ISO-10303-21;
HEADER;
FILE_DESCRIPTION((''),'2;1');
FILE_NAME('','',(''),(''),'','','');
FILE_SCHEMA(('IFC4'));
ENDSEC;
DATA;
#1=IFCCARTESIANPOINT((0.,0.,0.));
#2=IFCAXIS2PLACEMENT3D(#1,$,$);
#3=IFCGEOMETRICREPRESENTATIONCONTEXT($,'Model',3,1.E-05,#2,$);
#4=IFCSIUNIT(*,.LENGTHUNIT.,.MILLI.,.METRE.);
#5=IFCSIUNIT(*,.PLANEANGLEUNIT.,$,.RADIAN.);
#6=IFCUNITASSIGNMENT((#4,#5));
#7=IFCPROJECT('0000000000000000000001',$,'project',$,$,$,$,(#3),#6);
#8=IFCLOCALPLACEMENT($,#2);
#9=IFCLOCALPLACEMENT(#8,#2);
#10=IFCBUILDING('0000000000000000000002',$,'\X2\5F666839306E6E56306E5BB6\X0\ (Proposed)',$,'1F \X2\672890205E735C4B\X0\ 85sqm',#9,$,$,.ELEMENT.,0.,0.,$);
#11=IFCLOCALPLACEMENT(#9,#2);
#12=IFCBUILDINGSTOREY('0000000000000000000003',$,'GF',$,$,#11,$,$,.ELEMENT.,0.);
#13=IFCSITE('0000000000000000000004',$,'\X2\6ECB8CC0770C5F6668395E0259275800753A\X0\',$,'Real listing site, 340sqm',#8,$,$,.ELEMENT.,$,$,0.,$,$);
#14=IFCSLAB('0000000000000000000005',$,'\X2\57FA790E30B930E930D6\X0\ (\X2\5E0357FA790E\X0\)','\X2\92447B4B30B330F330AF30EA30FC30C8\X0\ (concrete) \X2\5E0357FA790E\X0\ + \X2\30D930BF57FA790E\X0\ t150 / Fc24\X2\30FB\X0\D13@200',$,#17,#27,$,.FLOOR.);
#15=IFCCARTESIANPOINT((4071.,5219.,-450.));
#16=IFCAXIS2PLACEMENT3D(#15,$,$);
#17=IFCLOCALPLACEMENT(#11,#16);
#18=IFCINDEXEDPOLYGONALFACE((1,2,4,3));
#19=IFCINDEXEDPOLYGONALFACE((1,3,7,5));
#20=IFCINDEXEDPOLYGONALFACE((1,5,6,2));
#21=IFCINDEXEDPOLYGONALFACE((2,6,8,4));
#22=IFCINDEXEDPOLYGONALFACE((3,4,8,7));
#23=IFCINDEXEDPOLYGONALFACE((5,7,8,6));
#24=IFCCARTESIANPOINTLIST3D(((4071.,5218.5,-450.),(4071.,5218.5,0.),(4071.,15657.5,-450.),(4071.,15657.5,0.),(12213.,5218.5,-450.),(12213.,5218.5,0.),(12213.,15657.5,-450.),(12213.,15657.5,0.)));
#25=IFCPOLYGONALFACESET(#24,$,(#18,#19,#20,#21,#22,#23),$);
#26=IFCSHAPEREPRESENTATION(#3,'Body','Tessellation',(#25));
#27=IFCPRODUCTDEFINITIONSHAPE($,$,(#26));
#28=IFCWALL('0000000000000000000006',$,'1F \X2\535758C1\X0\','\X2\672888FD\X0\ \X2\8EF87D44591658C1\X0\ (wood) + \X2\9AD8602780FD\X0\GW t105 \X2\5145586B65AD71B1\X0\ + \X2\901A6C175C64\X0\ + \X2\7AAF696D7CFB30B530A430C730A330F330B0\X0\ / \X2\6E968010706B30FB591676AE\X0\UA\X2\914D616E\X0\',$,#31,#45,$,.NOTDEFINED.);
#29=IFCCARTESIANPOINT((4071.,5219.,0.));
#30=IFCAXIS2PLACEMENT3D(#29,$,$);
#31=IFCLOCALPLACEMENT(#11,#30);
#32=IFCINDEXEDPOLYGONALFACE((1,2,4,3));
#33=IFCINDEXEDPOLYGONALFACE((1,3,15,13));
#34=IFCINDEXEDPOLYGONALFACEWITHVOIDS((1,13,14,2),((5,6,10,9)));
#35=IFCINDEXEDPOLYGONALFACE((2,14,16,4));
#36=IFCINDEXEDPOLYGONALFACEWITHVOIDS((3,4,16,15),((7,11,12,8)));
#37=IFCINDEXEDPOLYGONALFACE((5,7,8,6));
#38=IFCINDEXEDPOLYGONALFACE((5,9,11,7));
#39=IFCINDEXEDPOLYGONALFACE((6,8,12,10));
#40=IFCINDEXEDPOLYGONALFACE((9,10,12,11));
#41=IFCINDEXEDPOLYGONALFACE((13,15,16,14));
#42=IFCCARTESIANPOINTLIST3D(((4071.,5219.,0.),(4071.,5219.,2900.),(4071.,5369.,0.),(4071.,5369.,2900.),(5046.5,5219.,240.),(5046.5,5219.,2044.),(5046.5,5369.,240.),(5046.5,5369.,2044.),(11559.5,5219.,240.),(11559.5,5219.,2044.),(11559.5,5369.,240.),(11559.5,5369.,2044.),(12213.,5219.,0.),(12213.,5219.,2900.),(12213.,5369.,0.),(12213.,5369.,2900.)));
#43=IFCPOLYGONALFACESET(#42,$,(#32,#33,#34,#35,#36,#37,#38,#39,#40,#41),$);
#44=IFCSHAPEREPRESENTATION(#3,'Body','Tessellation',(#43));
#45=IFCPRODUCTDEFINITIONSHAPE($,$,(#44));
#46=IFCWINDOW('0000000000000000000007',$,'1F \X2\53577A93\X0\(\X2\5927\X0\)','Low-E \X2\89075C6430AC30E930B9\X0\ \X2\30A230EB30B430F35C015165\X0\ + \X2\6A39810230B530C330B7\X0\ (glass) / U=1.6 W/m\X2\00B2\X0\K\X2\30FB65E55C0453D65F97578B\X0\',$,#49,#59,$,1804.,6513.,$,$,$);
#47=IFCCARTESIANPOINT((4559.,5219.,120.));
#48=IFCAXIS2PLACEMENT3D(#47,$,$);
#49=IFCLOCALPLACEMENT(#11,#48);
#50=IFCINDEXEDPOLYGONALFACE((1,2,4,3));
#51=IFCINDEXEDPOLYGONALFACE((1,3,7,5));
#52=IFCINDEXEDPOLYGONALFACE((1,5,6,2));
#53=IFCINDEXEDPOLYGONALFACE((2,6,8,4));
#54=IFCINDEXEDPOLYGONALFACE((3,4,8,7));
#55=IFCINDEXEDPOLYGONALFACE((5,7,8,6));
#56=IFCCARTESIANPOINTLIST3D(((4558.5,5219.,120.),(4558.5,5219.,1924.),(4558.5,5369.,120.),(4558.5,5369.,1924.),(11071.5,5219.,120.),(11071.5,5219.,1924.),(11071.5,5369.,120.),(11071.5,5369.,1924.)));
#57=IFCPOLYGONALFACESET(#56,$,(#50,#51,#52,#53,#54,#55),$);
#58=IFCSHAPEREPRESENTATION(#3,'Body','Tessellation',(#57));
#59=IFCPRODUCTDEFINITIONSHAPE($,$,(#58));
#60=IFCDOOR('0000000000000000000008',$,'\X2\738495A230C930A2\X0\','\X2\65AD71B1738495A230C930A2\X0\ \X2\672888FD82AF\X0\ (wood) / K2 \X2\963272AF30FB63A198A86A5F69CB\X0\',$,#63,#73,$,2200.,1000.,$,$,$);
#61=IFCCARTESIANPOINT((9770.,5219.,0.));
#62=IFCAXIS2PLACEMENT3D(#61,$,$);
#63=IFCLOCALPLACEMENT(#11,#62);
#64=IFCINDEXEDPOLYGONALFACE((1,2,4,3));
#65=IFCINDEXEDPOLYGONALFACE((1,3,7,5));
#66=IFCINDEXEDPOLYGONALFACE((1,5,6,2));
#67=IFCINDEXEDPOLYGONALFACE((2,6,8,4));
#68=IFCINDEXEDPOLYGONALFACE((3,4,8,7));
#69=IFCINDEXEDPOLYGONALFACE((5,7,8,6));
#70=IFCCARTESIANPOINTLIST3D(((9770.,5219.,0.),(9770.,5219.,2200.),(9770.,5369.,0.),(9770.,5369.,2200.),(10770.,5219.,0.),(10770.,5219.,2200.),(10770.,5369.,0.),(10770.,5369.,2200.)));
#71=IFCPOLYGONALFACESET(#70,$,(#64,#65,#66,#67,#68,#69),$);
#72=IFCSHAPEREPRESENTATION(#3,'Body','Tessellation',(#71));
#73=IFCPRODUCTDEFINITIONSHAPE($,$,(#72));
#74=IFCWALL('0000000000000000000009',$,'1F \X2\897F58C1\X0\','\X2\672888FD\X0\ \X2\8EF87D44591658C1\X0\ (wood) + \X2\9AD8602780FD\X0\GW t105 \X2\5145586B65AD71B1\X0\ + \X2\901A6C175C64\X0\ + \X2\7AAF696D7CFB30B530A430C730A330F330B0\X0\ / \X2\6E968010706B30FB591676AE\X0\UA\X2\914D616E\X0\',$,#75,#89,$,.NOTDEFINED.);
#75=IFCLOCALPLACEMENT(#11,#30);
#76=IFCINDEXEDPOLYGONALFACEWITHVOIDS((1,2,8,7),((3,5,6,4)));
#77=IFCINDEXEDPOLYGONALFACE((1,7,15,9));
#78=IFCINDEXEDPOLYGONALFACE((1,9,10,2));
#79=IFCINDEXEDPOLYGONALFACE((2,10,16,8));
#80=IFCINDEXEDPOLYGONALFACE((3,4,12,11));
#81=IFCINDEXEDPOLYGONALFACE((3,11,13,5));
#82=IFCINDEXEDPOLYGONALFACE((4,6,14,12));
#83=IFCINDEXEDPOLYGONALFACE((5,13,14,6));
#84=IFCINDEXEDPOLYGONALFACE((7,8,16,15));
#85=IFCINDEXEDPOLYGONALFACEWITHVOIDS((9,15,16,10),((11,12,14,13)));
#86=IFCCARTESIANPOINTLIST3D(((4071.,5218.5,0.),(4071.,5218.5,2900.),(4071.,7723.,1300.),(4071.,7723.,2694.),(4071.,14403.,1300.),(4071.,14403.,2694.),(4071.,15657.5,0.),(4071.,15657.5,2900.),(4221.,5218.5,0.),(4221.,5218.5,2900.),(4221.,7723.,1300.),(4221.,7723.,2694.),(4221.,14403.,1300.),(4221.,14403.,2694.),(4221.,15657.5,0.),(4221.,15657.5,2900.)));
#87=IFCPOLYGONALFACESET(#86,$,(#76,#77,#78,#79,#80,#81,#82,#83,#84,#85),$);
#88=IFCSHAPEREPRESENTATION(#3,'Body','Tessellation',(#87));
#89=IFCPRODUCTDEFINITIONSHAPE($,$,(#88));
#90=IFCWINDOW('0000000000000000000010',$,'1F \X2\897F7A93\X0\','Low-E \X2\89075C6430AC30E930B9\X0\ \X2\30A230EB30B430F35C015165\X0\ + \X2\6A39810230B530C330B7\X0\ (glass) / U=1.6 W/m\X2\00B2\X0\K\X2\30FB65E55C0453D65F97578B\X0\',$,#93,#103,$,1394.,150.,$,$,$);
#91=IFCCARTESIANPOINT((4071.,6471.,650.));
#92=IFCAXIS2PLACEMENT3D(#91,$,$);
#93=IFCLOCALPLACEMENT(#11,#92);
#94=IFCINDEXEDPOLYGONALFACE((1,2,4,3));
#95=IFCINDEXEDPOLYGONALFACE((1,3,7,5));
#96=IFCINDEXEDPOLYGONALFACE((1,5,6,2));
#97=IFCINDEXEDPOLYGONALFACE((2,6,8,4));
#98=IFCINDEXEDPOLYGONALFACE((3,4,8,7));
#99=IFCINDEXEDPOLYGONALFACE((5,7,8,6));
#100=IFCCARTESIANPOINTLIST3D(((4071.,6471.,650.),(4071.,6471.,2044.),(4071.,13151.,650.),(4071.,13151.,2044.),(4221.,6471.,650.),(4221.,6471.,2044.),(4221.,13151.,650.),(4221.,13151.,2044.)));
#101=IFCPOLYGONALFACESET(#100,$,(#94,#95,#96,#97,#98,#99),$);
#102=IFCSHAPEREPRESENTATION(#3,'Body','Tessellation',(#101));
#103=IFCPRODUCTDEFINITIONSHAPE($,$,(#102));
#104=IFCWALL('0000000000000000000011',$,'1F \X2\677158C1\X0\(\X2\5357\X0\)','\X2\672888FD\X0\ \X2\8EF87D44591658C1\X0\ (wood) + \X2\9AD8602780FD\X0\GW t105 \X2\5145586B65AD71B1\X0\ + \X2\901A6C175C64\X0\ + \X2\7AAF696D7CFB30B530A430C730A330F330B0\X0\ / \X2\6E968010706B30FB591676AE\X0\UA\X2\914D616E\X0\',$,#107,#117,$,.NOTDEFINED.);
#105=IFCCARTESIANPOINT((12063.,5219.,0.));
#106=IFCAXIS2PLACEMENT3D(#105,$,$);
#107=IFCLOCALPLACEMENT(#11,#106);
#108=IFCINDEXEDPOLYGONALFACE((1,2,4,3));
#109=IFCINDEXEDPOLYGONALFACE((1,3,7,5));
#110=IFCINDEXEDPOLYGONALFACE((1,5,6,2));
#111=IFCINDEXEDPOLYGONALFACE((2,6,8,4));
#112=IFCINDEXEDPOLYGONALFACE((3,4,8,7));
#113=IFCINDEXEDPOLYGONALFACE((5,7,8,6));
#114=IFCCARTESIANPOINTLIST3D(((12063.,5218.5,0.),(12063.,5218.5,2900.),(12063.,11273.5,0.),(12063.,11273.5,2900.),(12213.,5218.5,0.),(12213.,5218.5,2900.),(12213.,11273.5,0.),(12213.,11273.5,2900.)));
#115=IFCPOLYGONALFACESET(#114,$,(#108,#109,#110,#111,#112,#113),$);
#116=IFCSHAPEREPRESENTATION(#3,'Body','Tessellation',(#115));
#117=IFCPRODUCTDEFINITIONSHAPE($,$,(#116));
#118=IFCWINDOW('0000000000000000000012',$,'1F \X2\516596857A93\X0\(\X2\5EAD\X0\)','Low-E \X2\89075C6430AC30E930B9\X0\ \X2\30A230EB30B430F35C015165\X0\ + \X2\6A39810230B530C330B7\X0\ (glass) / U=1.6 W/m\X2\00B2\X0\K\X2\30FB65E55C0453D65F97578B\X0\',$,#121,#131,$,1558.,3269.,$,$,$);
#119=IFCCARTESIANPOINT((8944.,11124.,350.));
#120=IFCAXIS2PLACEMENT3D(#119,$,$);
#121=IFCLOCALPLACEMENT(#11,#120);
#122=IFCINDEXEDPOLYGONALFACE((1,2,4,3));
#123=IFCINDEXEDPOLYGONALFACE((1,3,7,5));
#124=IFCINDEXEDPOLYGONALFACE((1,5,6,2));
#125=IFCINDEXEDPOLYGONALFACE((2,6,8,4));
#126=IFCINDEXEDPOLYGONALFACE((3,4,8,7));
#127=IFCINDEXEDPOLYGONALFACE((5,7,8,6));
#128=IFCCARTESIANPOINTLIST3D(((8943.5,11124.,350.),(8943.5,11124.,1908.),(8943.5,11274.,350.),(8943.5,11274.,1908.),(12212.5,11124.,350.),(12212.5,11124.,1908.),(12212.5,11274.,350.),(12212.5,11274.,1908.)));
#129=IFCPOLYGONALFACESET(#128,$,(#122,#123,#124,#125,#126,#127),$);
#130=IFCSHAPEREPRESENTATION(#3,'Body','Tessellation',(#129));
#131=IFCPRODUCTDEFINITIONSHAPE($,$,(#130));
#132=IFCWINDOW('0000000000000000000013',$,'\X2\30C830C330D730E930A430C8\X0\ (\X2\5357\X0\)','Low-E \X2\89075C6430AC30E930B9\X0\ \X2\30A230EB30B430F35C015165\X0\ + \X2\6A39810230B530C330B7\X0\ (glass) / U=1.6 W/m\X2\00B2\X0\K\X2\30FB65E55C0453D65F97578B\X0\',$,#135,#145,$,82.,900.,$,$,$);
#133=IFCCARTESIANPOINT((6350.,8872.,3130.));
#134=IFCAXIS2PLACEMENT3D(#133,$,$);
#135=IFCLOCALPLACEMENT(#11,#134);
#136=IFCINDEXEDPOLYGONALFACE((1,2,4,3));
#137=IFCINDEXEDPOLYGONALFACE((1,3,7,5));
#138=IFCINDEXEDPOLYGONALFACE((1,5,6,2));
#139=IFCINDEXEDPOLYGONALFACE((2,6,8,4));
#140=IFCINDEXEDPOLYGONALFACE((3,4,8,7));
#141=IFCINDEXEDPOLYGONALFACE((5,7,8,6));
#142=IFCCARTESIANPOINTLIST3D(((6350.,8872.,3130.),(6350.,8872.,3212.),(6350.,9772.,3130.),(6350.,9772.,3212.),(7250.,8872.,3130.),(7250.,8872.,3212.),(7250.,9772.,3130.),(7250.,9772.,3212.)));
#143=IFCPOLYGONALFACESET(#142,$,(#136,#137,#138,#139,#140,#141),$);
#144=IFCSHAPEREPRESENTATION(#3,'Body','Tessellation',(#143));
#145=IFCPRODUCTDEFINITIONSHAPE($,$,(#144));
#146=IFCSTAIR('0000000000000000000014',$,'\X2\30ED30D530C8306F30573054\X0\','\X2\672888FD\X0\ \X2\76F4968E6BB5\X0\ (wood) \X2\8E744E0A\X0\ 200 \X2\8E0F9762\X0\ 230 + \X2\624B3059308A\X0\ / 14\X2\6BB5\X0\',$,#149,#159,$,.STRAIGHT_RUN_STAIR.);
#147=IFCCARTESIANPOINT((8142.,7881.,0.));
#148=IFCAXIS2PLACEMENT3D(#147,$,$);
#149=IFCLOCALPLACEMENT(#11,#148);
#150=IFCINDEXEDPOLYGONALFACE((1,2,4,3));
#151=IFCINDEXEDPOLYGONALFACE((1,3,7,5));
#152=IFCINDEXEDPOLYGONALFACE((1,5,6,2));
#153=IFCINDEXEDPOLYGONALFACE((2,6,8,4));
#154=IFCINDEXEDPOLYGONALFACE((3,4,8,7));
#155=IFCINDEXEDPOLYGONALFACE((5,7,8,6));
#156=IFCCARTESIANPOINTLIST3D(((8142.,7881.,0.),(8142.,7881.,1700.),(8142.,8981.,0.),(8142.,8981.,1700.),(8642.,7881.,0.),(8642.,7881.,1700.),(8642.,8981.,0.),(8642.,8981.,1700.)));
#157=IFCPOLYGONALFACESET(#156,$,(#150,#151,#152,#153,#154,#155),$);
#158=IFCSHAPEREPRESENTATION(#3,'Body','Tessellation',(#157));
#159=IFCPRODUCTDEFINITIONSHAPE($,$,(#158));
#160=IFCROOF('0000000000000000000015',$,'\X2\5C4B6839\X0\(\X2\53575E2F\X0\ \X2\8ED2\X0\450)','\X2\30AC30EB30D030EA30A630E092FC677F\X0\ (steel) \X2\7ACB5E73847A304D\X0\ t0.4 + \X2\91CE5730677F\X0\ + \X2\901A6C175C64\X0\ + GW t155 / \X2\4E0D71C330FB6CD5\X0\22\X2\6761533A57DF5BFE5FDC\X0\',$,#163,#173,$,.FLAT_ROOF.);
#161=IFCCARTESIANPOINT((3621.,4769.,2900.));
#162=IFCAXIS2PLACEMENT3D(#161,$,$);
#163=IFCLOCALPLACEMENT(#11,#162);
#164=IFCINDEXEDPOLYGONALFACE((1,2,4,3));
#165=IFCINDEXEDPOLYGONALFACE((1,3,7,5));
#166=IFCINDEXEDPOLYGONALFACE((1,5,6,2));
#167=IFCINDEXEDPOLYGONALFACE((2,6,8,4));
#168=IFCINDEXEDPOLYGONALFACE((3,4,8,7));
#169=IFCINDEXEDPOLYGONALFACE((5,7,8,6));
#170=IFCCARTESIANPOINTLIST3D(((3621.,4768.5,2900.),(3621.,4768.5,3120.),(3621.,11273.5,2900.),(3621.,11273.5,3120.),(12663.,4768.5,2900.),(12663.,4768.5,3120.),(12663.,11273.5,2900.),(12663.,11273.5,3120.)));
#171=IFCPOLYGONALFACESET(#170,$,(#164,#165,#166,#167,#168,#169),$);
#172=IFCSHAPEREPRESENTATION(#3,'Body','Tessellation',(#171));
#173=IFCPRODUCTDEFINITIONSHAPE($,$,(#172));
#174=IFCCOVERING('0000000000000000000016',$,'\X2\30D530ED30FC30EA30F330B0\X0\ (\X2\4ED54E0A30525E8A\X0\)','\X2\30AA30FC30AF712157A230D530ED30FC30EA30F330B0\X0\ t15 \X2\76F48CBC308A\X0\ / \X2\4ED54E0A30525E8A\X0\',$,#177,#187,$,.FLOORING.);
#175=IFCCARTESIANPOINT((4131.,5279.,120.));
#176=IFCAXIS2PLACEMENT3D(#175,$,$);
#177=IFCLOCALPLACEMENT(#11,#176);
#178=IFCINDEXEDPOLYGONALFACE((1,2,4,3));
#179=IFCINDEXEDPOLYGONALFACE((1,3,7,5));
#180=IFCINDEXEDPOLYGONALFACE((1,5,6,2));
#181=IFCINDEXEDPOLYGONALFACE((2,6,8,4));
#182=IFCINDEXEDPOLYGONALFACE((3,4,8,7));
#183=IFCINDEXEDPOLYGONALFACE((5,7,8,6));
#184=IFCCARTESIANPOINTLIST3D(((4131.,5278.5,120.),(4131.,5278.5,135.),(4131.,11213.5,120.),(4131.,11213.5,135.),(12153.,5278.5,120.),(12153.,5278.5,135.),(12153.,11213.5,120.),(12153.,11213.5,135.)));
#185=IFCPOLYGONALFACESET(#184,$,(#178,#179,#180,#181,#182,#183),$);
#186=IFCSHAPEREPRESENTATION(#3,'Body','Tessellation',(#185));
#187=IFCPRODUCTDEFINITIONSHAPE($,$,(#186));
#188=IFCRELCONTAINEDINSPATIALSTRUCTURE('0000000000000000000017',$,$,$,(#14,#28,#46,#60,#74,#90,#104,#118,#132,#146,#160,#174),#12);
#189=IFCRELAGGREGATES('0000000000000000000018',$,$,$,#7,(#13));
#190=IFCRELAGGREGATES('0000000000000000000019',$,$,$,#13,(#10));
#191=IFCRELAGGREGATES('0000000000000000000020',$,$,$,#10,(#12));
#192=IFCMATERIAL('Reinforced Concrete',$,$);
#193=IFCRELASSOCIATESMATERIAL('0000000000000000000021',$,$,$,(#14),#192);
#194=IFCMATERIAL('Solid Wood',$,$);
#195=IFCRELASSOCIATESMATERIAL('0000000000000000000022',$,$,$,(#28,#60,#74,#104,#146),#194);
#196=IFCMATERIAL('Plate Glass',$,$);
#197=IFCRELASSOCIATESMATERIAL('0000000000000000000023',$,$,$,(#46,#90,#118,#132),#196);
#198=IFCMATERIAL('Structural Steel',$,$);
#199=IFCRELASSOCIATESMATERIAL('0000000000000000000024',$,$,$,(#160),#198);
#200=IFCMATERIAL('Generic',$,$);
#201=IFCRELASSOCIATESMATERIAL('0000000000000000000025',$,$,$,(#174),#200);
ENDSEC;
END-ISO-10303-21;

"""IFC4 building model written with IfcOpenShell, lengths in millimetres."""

from ifc_helpers import new_model, si_unit, frame, frame_2d, origin, place, context, project, spatial, rectangle, extrude, material, element, fill, save


model = new_model("IFC4")

# Units and contexts
model_context = context("Model", 3, precision=1e-05, world=origin())
ifc_project = project(units=[si_unit("LENGTHUNIT", "METRE", prefix="MILLI"), si_unit("PLANEANGLEUNIT", "RADIAN")], contexts=[model_context])

# Site, building, storey
site_placement = place(None, origin())
site = spatial("IfcSite", under=ifc_project, at=site_placement, Name="滋賀県彦根市大堀町", ObjectType="Real listing site, 340sqm", CompositionType="ELEMENT", RefElevation=0.0)
building_placement = place(site_placement, origin())
building = spatial("IfcBuilding", under=site, at=building_placement, Name="彦根の湖の家 (Proposed)", ObjectType="1F 木造平屋 85sqm", CompositionType="ELEMENT", ElevationOfRefHeight=0.0, ElevationOfTerrain=0.0)
storey_placement = place(building_placement, origin())
storey = spatial("IfcBuildingStorey", under=building, at=storey_placement, Name="GF", CompositionType="ELEMENT", Elevation=0.0)

# Slab
ifc_material_1 = material(Name="Reinforced Concrete")
slab_1_placement = place(storey_placement, frame((4071.0, 5219.0, -450.0)))
element("IfcSlab", 1, at=slab_1_placement, inside=storey, material=ifc_material_1, Name="基礎スラブ (布基礎)", Description="鉄筋コンクリート (concrete) 布基礎 + ベタ基礎 t150 / Fc24・D13@200", PredefinedType="FLOOR", context=model_context, shape_type="SweptSolid", body=[
    extrude(rectangle(XDim=8142.0, YDim=10439.0, at=frame_2d((4071.0, 5219.0))), frame((4071.0, 5219.0, -450.0)), (0.0, 0.0, 1.0), 450.0),
])
ifc_material_2 = material(Name="Solid Wood")

# Wall, openings, window, door
wall_1_placement = place(storey_placement, frame((4071.0, 5219.0, 0.0)))
wall_1 = element("IfcWall", 2, at=wall_1_placement, inside=storey, material=ifc_material_2, Name="1F 南壁", Description="木製 軸組外壁 (wood) + 高性能GW t105 充填断熱 + 通気層 + 窯業系サイディング / 準耐火・外皮UA配慮", PredefinedType="NOTDEFINED", context=model_context, shape_type="SweptSolid", body=[
    extrude(rectangle(XDim=8142.0, YDim=150.0, at=frame_2d((4071.0, 75.0))), frame((4071.0, 5219.0, 0.0)), (0.0, 0.0, 1.0), 2900.0),
])
opening_1_placement = place(storey_placement, frame((4559.0, 5219.0, 120.0)))
opening_1 = element("IfcOpeningElement", 3, at=opening_1_placement, cuts=wall_1, PredefinedType="NOTDEFINED", context=model_context, shape_type="SweptSolid", body=[
    extrude(rectangle(XDim=6513.0, YDim=150.0, at=frame_2d((3256.0, 75.0))), frame((4559.0, 5219.0, 120.0)), (0.0, 0.0, 1.0), 1804.0),
])
opening_2_placement = place(storey_placement, frame((9770.0, 5219.0, 0.0)))
opening_2 = element("IfcOpeningElement", 4, at=opening_2_placement, cuts=wall_1, PredefinedType="NOTDEFINED", context=model_context, shape_type="SweptSolid", body=[
    extrude(rectangle(XDim=1000.0, YDim=150.0, at=frame_2d((500.0, 75.0))), frame((9770.0, 5219.0, 0.0)), (0.0, 0.0, 1.0), 2200.0),
])
ifc_material_3 = material(Name="Plate Glass")
window_1_placement = place(storey_placement, frame((4559.0, 5219.0, 120.0)))
window_1 = element("IfcWindow", 5, at=window_1_placement, inside=storey, material=ifc_material_3, Name="1F 南窓(大)", Description="Low-E 複層ガラス アルゴン封入 + 樹脂サッシ (glass) / U=1.6 W/m²K・日射取得型", OverallHeight=1804.0, OverallWidth=6513.0, context=model_context, shape_type="SweptSolid", body=[
    extrude(rectangle(XDim=6513.0, YDim=150.0, at=frame_2d((3256.0, 75.0))), frame((4559.0, 5219.0, 120.0)), (0.0, 0.0, 1.0), 1804.0),
])
fill(opening_1, window_1)
door_1_placement = place(storey_placement, frame((9770.0, 5219.0, 0.0)))
door_1 = element("IfcDoor", 6, at=door_1_placement, inside=storey, material=ifc_material_2, Name="玄関ドア", Description="断熱玄関ドア 木製芯 (wood) / K2 防犯・採風機構", OverallHeight=2200.0, OverallWidth=1000.0, context=model_context, shape_type="SweptSolid", body=[
    extrude(rectangle(XDim=1000.0, YDim=150.0, at=frame_2d((500.0, 75.0))), frame((9770.0, 5219.0, 0.0)), (0.0, 0.0, 1.0), 2200.0),
])
fill(opening_2, door_1)

# Walls, openings, windows
wall_2_placement = place(storey_placement, frame((4071.0, 5219.0, 0.0)))
wall_2 = element("IfcWall", 7, at=wall_2_placement, inside=storey, material=ifc_material_2, Name="1F 西壁", Description="木製 軸組外壁 (wood) + 高性能GW t105 充填断熱 + 通気層 + 窯業系サイディング / 準耐火・外皮UA配慮", PredefinedType="NOTDEFINED", context=model_context, shape_type="SweptSolid", body=[
    extrude(rectangle(XDim=150.0, YDim=10439.0, at=frame_2d((75.0, 5219.0))), frame((4071.0, 5219.0, 0.0)), (0.0, 0.0, 1.0), 2900.0),
])
opening_3_placement = place(storey_placement, frame((4071.0, 6471.0, 650.0)))
opening_3 = element("IfcOpeningElement", 8, at=opening_3_placement, cuts=wall_2, PredefinedType="NOTDEFINED", context=model_context, shape_type="SweptSolid", body=[
    extrude(rectangle(XDim=150.0, YDim=6680.0, at=frame_2d((75.0, 3340.0))), frame((4071.0, 6471.0, 650.0)), (0.0, 0.0, 1.0), 1394.0),
])
window_2_placement = place(storey_placement, frame((4071.0, 6471.0, 650.0)))
window_2 = element("IfcWindow", 9, at=window_2_placement, inside=storey, material=ifc_material_3, Name="1F 西窓", Description="Low-E 複層ガラス アルゴン封入 + 樹脂サッシ (glass) / U=1.6 W/m²K・日射取得型", OverallHeight=1394.0, OverallWidth=150.0, context=model_context, shape_type="SweptSolid", body=[
    extrude(rectangle(XDim=150.0, YDim=6680.0, at=frame_2d((75.0, 3340.0))), frame((4071.0, 6471.0, 650.0)), (0.0, 0.0, 1.0), 1394.0),
])
fill(opening_3, window_2)
wall_3_placement = place(storey_placement, frame((12063.0, 5219.0, 0.0)))
wall_3 = element("IfcWall", 10, at=wall_3_placement, inside=storey, material=ifc_material_2, Name="1F 東壁(南)", Description="木製 軸組外壁 (wood) + 高性能GW t105 充填断熱 + 通気層 + 窯業系サイディング / 準耐火・外皮UA配慮", PredefinedType="NOTDEFINED", context=model_context, shape_type="SweptSolid", body=[
    extrude(rectangle(XDim=150.0, YDim=6055.0, at=frame_2d((75.0, 3027.0))), frame((12063.0, 5219.0, 0.0)), (0.0, 0.0, 1.0), 2900.0),
])
opening_4_placement = place(storey_placement, frame((8944.0, 11124.0, 350.0)))
opening_4 = element("IfcOpeningElement", 11, at=opening_4_placement, cuts=wall_3, PredefinedType="NOTDEFINED", context=model_context, shape_type="SweptSolid", body=[
    extrude(rectangle(XDim=3269.0, YDim=150.0, at=frame_2d((1634.0, 75.0))), frame((8944.0, 11124.0, 350.0)), (0.0, 0.0, 1.0), 1558.0),
])
window_3_placement = place(storey_placement, frame((8944.0, 11124.0, 350.0)))
window_3 = element("IfcWindow", 12, at=window_3_placement, inside=storey, material=ifc_material_3, Name="1F 入隅窓(庭)", Description="Low-E 複層ガラス アルゴン封入 + 樹脂サッシ (glass) / U=1.6 W/m²K・日射取得型", OverallHeight=1558.0, OverallWidth=3269.0, context=model_context, shape_type="SweptSolid", body=[
    extrude(rectangle(XDim=3269.0, YDim=150.0, at=frame_2d((1634.0, 75.0))), frame((8944.0, 11124.0, 350.0)), (0.0, 0.0, 1.0), 1558.0),
])
fill(opening_4, window_3)

# Window
window_4_placement = place(storey_placement, frame((6350.0, 8872.0, 3130.0)))
element("IfcWindow", 13, at=window_4_placement, inside=storey, material=ifc_material_3, Name="トップライト (南)", Description="Low-E 複層ガラス アルゴン封入 + 樹脂サッシ (glass) / U=1.6 W/m²K・日射取得型", OverallHeight=82.0, OverallWidth=900.0, context=model_context, shape_type="SweptSolid", body=[
    extrude(rectangle(XDim=900.0, YDim=900.0, at=frame_2d((450.0, 450.0))), frame((6350.0, 8872.0, 3130.0)), (0.0, 0.0, 1.0), 82.0),
])

# Stair
stair_placement = place(storey_placement, frame((8142.0, 7881.0, 0.0)))
element("IfcStair", 14, at=stair_placement, inside=storey, material=ifc_material_2, Name="ロフトはしご", Description="木製 直階段 (wood) 蹴上 200 踏面 230 + 手すり / 14段", PredefinedType="STRAIGHT_RUN_STAIR", context=model_context, shape_type="SweptSolid", body=[
    extrude(rectangle(XDim=500.0, YDim=1100.0, at=frame_2d((250.0, 550.0))), frame((8142.0, 7881.0, 0.0)), (0.0, 0.0, 1.0), 1700.0),
])

# Roof
ifc_material_4 = material(Name="Structural Steel")
roof_placement = place(storey_placement, frame((3621.0, 4769.0, 2900.0)))
element("IfcRoof", 15, at=roof_placement, inside=storey, material=ifc_material_4, Name="屋根(南帯 軒450)", Description="ガルバリウム鋼板 (steel) 立平葺き t0.4 + 野地板 + 通気層 + GW t155 / 不燃・法22条区域対応", PredefinedType="FLAT_ROOF", context=model_context, shape_type="SweptSolid", body=[
    extrude(rectangle(XDim=9042.0, YDim=6505.0, at=frame_2d((4521.0, 3252.0))), frame((3621.0, 4769.0, 2900.0)), (0.0, 0.0, 1.0), 220.0),
])

# Covering
ifc_material_5 = material(Name="Generic")
covering_placement = place(storey_placement, frame((4131.0, 5279.0, 120.0)))
element("IfcCovering", 16, at=covering_placement, inside=storey, material=ifc_material_5, Name="フローリング (仕上げ床)", Description="オーク無垢フローリング t15 直貼り / 仕上げ床", PredefinedType="FLOORING", context=model_context, shape_type="SweptSolid", body=[
    extrude(rectangle(XDim=8022.0, YDim=5935.0, at=frame_2d((4011.0, 2967.0))), frame((4131.0, 5279.0, 120.0)), (0.0, 0.0, 1.0), 15.0),
])

save(model, "model.ifc")
